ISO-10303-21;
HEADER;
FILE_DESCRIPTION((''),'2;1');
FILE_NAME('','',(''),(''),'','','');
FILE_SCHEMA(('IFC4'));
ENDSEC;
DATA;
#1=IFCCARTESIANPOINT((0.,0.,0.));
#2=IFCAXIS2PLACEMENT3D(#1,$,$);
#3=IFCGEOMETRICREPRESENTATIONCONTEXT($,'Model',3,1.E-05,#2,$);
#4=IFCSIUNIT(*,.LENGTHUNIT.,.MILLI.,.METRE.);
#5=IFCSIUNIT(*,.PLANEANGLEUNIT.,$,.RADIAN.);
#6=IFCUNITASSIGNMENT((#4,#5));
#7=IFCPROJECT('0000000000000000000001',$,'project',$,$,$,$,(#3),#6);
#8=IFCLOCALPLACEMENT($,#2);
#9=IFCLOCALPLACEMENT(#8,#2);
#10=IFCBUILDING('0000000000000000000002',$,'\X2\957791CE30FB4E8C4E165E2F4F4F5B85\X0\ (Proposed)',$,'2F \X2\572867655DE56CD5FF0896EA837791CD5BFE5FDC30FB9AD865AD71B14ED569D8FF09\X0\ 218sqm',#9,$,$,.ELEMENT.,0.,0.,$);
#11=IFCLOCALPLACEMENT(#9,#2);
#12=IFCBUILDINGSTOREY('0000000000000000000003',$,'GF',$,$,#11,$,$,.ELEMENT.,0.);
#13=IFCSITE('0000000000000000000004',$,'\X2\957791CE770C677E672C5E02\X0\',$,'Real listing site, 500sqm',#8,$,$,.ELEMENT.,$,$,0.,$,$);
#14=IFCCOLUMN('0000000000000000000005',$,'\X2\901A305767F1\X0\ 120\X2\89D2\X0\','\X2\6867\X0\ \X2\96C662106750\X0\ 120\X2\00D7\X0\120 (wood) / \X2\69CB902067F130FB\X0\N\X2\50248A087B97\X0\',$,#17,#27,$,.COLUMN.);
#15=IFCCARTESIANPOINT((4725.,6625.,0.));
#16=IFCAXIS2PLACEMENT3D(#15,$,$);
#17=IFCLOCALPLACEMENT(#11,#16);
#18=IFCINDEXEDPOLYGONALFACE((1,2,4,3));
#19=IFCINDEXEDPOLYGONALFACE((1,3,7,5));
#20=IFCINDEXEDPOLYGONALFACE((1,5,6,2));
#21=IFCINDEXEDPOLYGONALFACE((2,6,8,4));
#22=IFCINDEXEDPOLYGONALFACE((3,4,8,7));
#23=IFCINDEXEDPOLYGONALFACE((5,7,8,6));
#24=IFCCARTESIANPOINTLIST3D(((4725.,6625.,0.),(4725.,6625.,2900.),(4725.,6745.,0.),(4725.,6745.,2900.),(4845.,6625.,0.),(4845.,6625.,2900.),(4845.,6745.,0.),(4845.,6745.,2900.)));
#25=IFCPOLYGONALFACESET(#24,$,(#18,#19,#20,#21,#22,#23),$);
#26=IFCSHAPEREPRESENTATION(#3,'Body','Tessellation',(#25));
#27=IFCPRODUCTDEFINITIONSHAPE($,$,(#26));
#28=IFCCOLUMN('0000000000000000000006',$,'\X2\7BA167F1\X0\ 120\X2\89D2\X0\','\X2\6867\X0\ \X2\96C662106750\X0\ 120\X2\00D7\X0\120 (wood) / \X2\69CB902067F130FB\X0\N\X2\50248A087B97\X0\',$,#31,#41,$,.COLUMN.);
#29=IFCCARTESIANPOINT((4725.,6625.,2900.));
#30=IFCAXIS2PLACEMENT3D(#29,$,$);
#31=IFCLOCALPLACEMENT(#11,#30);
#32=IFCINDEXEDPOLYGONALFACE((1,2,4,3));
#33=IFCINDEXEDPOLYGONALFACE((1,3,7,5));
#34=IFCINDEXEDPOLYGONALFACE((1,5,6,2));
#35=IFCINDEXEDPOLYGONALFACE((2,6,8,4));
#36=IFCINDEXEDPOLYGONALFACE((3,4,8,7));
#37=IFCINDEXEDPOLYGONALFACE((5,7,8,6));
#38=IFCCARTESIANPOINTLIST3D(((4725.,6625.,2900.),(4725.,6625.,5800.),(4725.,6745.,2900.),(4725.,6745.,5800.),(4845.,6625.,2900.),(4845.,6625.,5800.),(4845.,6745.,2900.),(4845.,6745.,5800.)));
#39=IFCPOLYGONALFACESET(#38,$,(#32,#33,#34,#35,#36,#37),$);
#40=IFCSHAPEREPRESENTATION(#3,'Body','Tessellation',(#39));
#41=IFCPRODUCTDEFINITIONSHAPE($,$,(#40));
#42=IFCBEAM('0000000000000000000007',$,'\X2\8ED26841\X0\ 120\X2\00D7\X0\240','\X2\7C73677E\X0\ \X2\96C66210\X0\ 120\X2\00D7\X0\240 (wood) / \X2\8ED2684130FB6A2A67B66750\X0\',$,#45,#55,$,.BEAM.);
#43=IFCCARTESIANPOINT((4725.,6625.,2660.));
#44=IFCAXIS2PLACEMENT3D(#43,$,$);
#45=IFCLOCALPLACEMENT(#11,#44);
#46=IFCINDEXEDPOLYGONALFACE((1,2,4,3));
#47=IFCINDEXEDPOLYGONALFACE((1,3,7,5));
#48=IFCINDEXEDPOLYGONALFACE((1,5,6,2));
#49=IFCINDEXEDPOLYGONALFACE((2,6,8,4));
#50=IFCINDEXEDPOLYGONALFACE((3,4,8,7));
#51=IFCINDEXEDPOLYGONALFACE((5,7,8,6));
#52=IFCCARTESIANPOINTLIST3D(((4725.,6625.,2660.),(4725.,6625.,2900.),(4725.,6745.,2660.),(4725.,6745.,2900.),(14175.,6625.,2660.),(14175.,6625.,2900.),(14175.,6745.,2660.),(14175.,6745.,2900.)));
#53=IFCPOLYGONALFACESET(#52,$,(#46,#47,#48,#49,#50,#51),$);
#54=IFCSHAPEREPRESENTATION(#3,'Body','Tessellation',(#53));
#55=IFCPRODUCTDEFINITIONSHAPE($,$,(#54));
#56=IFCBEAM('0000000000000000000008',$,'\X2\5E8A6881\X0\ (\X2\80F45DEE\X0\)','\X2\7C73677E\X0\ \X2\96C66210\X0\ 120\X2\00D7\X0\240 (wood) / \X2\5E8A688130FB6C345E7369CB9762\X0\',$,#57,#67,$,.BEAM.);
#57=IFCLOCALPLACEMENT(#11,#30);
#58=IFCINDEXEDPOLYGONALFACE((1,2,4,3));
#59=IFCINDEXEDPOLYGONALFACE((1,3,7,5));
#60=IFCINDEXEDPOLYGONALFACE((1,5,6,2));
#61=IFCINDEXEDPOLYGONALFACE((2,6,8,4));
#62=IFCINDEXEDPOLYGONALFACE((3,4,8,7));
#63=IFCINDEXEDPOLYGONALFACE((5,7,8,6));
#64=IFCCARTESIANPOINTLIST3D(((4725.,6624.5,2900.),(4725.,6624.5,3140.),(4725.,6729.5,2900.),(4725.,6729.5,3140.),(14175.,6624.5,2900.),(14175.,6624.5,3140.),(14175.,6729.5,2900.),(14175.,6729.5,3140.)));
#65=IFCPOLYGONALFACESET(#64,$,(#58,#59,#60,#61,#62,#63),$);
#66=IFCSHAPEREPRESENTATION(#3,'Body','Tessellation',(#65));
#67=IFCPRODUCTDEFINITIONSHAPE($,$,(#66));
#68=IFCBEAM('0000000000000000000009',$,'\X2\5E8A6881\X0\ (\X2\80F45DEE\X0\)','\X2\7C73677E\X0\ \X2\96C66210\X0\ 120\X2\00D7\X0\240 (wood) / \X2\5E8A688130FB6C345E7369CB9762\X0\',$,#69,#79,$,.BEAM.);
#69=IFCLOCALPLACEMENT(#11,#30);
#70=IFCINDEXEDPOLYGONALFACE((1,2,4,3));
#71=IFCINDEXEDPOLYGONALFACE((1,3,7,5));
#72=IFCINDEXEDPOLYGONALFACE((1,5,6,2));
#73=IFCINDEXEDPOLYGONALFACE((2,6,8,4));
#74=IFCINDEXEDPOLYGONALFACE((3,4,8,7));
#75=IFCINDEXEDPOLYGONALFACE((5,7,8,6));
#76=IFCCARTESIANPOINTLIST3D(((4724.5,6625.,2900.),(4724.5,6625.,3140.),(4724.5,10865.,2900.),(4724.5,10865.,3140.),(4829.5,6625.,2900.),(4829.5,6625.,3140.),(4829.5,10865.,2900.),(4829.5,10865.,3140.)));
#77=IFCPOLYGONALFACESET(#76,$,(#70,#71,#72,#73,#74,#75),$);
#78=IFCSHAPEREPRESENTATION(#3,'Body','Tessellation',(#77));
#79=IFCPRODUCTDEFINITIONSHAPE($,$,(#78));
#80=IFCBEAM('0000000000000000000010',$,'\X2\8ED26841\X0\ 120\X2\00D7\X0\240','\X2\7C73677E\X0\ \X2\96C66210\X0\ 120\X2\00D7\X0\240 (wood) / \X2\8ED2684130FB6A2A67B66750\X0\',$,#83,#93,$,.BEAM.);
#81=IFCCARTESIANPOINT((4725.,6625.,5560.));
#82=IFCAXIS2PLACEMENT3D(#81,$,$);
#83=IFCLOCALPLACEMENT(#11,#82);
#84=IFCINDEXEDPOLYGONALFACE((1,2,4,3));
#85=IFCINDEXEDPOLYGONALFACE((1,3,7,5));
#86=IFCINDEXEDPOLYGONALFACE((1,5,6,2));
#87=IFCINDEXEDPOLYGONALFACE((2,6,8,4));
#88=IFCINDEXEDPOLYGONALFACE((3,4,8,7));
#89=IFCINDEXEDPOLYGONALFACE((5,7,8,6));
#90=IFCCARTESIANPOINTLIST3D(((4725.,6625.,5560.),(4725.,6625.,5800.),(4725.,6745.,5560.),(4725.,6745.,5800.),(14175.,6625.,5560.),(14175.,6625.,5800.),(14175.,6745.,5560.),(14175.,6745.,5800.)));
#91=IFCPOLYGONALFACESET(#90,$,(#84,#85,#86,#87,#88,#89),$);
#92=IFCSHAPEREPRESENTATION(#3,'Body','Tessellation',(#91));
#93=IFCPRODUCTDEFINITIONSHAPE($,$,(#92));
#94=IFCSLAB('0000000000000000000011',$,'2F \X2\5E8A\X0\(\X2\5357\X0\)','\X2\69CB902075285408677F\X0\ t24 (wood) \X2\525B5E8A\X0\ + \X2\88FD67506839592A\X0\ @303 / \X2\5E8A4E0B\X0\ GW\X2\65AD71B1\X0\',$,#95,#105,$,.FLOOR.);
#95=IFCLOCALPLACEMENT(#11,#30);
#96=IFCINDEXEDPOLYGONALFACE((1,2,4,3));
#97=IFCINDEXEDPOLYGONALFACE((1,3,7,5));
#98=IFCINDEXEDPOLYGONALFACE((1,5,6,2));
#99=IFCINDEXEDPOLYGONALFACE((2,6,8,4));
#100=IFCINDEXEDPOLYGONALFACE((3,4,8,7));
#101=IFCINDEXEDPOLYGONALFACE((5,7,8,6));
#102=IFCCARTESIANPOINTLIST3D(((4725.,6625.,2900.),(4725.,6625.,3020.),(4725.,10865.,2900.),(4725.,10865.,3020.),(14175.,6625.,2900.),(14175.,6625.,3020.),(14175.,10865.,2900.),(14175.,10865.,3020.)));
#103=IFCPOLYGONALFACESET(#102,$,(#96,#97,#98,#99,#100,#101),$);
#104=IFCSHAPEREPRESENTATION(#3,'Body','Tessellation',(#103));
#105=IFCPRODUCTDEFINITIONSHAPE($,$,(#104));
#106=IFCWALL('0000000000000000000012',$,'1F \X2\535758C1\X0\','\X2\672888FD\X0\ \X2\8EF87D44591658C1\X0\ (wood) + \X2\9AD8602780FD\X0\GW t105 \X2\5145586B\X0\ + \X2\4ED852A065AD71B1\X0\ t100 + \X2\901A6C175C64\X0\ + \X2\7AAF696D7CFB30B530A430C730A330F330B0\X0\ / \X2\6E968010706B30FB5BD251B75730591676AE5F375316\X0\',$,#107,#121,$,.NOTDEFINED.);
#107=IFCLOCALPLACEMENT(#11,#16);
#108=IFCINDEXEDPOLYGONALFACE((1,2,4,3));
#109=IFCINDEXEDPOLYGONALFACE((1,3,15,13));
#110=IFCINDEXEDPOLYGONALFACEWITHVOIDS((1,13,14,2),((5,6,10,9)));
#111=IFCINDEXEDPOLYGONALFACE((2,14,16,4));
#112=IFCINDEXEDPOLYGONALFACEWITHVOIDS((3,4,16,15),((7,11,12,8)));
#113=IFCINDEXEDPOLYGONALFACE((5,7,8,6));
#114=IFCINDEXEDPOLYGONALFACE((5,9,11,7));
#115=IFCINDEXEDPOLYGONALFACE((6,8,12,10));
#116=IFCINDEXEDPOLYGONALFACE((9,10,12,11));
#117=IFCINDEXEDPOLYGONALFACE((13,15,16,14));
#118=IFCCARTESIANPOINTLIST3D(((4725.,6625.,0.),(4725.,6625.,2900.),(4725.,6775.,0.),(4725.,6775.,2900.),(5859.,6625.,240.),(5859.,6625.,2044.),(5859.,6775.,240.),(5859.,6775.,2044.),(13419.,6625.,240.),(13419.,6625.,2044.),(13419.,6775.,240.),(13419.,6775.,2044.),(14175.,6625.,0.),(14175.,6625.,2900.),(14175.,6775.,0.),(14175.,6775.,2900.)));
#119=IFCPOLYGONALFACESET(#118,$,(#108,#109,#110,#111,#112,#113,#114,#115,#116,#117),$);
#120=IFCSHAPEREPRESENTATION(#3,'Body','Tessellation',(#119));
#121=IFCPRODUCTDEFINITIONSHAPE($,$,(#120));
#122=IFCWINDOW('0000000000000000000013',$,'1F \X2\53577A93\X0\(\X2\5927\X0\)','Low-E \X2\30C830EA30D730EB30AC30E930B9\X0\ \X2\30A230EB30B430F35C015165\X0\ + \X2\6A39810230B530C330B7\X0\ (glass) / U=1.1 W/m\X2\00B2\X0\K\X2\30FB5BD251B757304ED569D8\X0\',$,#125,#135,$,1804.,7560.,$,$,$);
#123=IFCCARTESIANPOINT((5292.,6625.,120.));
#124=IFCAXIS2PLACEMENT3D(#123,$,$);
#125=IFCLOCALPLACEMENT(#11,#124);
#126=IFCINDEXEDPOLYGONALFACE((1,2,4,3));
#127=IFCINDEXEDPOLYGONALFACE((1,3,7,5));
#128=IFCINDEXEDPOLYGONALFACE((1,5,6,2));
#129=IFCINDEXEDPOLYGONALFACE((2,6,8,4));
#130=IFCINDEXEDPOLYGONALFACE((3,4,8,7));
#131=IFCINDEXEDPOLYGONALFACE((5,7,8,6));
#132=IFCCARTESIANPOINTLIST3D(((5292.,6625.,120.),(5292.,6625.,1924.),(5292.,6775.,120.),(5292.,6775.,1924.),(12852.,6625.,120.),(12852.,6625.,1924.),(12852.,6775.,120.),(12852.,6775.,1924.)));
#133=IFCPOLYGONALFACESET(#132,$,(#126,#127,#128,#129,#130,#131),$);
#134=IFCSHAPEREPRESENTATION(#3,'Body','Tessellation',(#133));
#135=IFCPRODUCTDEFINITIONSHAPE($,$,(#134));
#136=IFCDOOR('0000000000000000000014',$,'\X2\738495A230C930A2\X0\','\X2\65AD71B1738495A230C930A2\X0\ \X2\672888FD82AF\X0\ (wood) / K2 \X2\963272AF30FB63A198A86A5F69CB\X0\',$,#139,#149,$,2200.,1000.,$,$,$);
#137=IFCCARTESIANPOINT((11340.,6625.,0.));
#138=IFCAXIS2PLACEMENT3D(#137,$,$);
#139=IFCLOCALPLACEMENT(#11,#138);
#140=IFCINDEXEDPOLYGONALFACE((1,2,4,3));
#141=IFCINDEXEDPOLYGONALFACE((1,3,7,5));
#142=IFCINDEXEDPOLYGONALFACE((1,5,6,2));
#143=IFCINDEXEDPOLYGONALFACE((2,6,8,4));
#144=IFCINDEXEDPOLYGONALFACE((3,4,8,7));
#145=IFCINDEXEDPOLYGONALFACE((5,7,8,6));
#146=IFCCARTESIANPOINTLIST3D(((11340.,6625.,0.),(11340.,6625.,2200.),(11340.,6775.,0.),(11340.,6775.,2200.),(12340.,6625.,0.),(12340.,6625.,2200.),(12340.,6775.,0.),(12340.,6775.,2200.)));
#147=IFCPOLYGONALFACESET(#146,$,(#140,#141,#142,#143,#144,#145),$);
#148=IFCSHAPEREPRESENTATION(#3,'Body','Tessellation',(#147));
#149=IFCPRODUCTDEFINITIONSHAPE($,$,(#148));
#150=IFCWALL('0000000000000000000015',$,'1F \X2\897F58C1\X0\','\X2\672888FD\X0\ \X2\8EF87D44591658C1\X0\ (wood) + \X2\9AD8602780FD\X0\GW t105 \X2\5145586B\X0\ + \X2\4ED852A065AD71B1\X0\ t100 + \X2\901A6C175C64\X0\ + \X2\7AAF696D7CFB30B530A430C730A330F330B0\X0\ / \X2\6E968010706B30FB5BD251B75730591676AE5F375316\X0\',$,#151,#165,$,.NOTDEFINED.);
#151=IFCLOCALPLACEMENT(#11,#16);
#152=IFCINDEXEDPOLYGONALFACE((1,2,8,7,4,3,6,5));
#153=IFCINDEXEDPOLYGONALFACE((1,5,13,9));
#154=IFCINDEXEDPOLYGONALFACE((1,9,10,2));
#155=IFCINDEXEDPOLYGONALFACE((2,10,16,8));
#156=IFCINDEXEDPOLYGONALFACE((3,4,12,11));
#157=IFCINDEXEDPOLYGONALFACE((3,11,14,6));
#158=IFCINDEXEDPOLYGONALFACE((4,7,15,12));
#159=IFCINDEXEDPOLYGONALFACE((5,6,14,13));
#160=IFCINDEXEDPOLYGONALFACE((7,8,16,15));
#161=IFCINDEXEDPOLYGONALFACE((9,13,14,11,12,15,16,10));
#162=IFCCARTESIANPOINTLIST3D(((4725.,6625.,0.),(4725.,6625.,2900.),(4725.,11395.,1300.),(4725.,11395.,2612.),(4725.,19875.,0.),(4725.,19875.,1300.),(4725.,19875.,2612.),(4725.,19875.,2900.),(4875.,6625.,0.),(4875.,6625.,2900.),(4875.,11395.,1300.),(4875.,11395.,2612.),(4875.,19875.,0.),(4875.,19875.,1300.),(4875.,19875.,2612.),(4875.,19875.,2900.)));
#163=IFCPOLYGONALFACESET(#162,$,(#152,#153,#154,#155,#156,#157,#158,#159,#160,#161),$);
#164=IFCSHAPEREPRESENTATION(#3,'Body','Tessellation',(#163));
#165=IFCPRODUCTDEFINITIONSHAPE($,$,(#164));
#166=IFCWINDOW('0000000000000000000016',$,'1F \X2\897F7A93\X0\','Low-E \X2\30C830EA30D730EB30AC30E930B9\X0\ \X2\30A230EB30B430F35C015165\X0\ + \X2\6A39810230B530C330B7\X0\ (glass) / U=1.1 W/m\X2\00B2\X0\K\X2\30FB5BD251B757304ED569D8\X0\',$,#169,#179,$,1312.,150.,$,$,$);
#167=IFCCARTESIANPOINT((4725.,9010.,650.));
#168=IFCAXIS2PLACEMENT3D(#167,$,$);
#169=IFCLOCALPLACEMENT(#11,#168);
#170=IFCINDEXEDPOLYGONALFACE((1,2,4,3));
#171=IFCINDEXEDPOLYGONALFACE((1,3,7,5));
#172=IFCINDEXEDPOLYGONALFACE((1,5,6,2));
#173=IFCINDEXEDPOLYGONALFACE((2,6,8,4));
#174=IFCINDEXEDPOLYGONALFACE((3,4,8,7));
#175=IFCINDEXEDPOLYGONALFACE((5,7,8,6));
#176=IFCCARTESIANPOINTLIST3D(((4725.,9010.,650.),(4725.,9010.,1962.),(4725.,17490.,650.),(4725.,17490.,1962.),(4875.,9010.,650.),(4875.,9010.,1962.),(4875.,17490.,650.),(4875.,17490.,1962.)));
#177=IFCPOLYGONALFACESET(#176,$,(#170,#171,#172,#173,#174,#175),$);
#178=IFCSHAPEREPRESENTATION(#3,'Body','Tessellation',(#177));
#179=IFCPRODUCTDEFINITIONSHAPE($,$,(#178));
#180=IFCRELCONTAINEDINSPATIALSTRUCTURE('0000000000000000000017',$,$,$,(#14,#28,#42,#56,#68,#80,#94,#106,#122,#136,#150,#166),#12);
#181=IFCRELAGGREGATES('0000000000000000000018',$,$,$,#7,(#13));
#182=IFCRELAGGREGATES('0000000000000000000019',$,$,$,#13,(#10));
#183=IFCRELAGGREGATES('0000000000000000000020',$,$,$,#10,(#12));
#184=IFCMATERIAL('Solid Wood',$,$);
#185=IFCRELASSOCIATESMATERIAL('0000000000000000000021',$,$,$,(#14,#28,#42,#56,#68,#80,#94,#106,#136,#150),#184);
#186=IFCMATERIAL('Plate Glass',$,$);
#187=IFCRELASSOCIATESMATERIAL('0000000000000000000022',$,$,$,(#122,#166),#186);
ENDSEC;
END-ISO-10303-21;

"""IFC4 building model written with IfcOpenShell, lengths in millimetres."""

from ifc_helpers import new_model, si_unit, frame, frame_2d, origin, place, context, project, spatial, rectangle, extrude, material, element, fill, save


model = new_model("IFC4")

# Units and contexts
model_context = context("Model", 3, precision=1e-05, world=origin())
ifc_project = project(units=[si_unit("LENGTHUNIT", "METRE", prefix="MILLI"), si_unit("PLANEANGLEUNIT", "RADIAN")], contexts=[model_context])

# Site, building, storey
site_placement = place(None, origin())
site = spatial("IfcSite", under=ifc_project, at=site_placement, Name="長野県松本市", ObjectType="Real listing site, 500sqm", CompositionType="ELEMENT", RefElevation=0.0)
building_placement = place(site_placement, origin())
building = spatial("IfcBuilding", under=site, at=building_placement, Name="長野・二世帯住宅 (Proposed)", ObjectType="2F 在来工法（雪荷重対応・高断熱仕様） 218sqm", CompositionType="ELEMENT", ElevationOfRefHeight=0.0, ElevationOfTerrain=0.0)
storey_placement = place(building_placement, origin())
storey = spatial("IfcBuildingStorey", under=building, at=storey_placement, Name="GF", CompositionType="ELEMENT", Elevation=0.0)

# Columns
ifc_material_1 = material(Name="Solid Wood")
column_1_placement = place(storey_placement, frame((4725.0, 6625.0, 0.0)))
element("IfcColumn", 1, at=column_1_placement, inside=storey, material=ifc_material_1, Name="通し柱 120角", Description="桧 集成材 120×120 (wood) / 構造柱・N値計算", PredefinedType="COLUMN", context=model_context, shape_type="SweptSolid", body=[
    extrude(rectangle(XDim=120.0, YDim=120.0, at=frame_2d((60.0, 60.0))), frame((4725.0, 6625.0, 0.0)), (0.0, 0.0, 1.0), 2900.0),
])
column_2_placement = place(storey_placement, frame((4725.0, 6625.0, 2900.0)))
element("IfcColumn", 2, at=column_2_placement, inside=storey, material=ifc_material_1, Name="管柱 120角", Description="桧 集成材 120×120 (wood) / 構造柱・N値計算", PredefinedType="COLUMN", context=model_context, shape_type="SweptSolid", body=[
    extrude(rectangle(XDim=120.0, YDim=120.0, at=frame_2d((60.0, 60.0))), frame((4725.0, 6625.0, 2900.0)), (0.0, 0.0, 1.0), 2900.0),
])

# Beams
beam_1_placement = place(storey_placement, frame((4725.0, 6625.0, 2660.0)))
element("IfcBeam", 3, at=beam_1_placement, inside=storey, material=ifc_material_1, Name="軒桁 120×240", Description="米松 集成 120×240 (wood) / 軒桁・横架材", PredefinedType="BEAM", context=model_context, shape_type="SweptSolid", body=[
    extrude(rectangle(XDim=9450.0, YDim=120.0, at=frame_2d((4725.0, 60.0))), frame((4725.0, 6625.0, 2660.0)), (0.0, 0.0, 1.0), 240.0),
])
beam_2_placement = place(storey_placement, frame((4725.0, 6625.0, 2900.0)))
element("IfcBeam", 4, at=beam_2_placement, inside=storey, material=ifc_material_1, Name="床梁 (胴差)", Description="米松 集成 120×240 (wood) / 床梁・水平構面", PredefinedType="BEAM", context=model_context, shape_type="SweptSolid", body=[
    extrude(rectangle(XDim=9450.0, YDim=105.0, at=frame_2d((4725.0, 52.0))), frame((4725.0, 6625.0, 2900.0)), (0.0, 0.0, 1.0), 240.0),
])
beam_3_placement = place(storey_placement, frame((4725.0, 6625.0, 2900.0)))
element("IfcBeam", 5, at=beam_3_placement, inside=storey, material=ifc_material_1, Name="床梁 (胴差)", Description="米松 集成 120×240 (wood) / 床梁・水平構面", PredefinedType="BEAM", context=model_context, shape_type="SweptSolid", body=[
    extrude(rectangle(XDim=105.0, YDim=4240.0, at=frame_2d((52.0, 2120.0))), frame((4725.0, 6625.0, 2900.0)), (0.0, 0.0, 1.0), 240.0),
])
beam_4_placement = place(storey_placement, frame((4725.0, 6625.0, 5560.0)))
element("IfcBeam", 6, at=beam_4_placement, inside=storey, material=ifc_material_1, Name="軒桁 120×240", Description="米松 集成 120×240 (wood) / 軒桁・横架材", PredefinedType="BEAM", context=model_context, shape_type="SweptSolid", body=[
    extrude(rectangle(XDim=9450.0, YDim=120.0, at=frame_2d((4725.0, 60.0))), frame((4725.0, 6625.0, 5560.0)), (0.0, 0.0, 1.0), 240.0),
])

# Slab
slab_1_placement = place(storey_placement, frame((4725.0, 6625.0, 2900.0)))
element("IfcSlab", 7, at=slab_1_placement, inside=storey, material=ifc_material_1, Name="2F 床(南)", Description="構造用合板 t24 (wood) 剛床 + 製材根太 @303 / 床下 GW断熱", PredefinedType="FLOOR", context=model_context, shape_type="SweptSolid", body=[
    extrude(rectangle(XDim=9450.0, YDim=4240.0, at=frame_2d((4725.0, 2120.0))), frame((4725.0, 6625.0, 2900.0)), (0.0, 0.0, 1.0), 120.0),
])

# Wall, openings, window, door
wall_1_placement = place(storey_placement, frame((4725.0, 6625.0, 0.0)))
wall_1 = element("IfcWall", 8, at=wall_1_placement, inside=storey, material=ifc_material_1, Name="1F 南壁", Description="木製 軸組外壁 (wood) + 高性能GW t105 充填 + 付加断熱 t100 + 通気層 + 窯業系サイディング / 準耐火・寒冷地外皮強化", PredefinedType="NOTDEFINED", context=model_context, shape_type="SweptSolid", body=[
    extrude(rectangle(XDim=9450.0, YDim=150.0, at=frame_2d((4725.0, 75.0))), frame((4725.0, 6625.0, 0.0)), (0.0, 0.0, 1.0), 2900.0),
])
opening_1_placement = place(storey_placement, frame((5292.0, 6625.0, 120.0)))
opening_1 = element("IfcOpeningElement", 9, at=opening_1_placement, cuts=wall_1, PredefinedType="NOTDEFINED", context=model_context, shape_type="SweptSolid", body=[
    extrude(rectangle(XDim=7560.0, YDim=150.0, at=frame_2d((3780.0, 75.0))), frame((5292.0, 6625.0, 120.0)), (0.0, 0.0, 1.0), 1804.0),
])
opening_2_placement = place(storey_placement, frame((11340.0, 6625.0, 0.0)))
opening_2 = element("IfcOpeningElement", 10, at=opening_2_placement, cuts=wall_1, PredefinedType="NOTDEFINED", context=model_context, shape_type="SweptSolid", body=[
    extrude(rectangle(XDim=1000.0, YDim=150.0, at=frame_2d((500.0, 75.0))), frame((11340.0, 6625.0, 0.0)), (0.0, 0.0, 1.0), 2200.0),
])
ifc_material_2 = material(Name="Plate Glass")
window_1_placement = place(storey_placement, frame((5292.0, 6625.0, 120.0)))
window_1 = element("IfcWindow", 11, at=window_1_placement, inside=storey, material=ifc_material_2, Name="1F 南窓(大)", Description="Low-E トリプルガラス アルゴン封入 + 樹脂サッシ (glass) / U=1.1 W/m²K・寒冷地仕様", OverallHeight=1804.0, OverallWidth=7560.0, context=model_context, shape_type="SweptSolid", body=[
    extrude(rectangle(XDim=7560.0, YDim=150.0, at=frame_2d((3780.0, 75.0))), frame((5292.0, 6625.0, 120.0)), (0.0, 0.0, 1.0), 1804.0),
])
fill(opening_1, window_1)
door_placement = place(storey_placement, frame((11340.0, 6625.0, 0.0)))
door = element("IfcDoor", 12, at=door_placement, inside=storey, material=ifc_material_1, Name="玄関ドア", Description="断熱玄関ドア 木製芯 (wood) / K2 防犯・採風機構", OverallHeight=2200.0, OverallWidth=1000.0, context=model_context, shape_type="SweptSolid", body=[
    extrude(rectangle(XDim=1000.0, YDim=150.0, at=frame_2d((500.0, 75.0))), frame((11340.0, 6625.0, 0.0)), (0.0, 0.0, 1.0), 2200.0),
])
fill(opening_2, door)

# Wall, opening, window
wall_2_placement = place(storey_placement, frame((4725.0, 6625.0, 0.0)))
wall_2 = element("IfcWall", 13, at=wall_2_placement, inside=storey, material=ifc_material_1, Name="1F 西壁", Description="木製 軸組外壁 (wood) + 高性能GW t105 充填 + 付加断熱 t100 + 通気層 + 窯業系サイディング / 準耐火・寒冷地外皮強化", PredefinedType="NOTDEFINED", context=model_context, shape_type="SweptSolid", body=[
    extrude(rectangle(XDim=150.0, YDim=13250.0, at=frame_2d((75.0, 6625.0))), frame((4725.0, 6625.0, 0.0)), (0.0, 0.0, 1.0), 2900.0),
])
opening_3_placement = place(storey_placement, frame((4725.0, 9010.0, 650.0)))
opening_3 = element("IfcOpeningElement", 14, at=opening_3_placement, cuts=wall_2, PredefinedType="NOTDEFINED", context=model_context, shape_type="SweptSolid", body=[
    extrude(rectangle(XDim=150.0, YDim=8480.0, at=frame_2d((75.0, 4240.0))), frame((4725.0, 9010.0, 650.0)), (0.0, 0.0, 1.0), 1312.0),
])
window_2_placement = place(storey_placement, frame((4725.0, 9010.0, 650.0)))
window_2 = element("IfcWindow", 15, at=window_2_placement, inside=storey, material=ifc_material_2, Name="1F 西窓", Description="Low-E トリプルガラス アルゴン封入 + 樹脂サッシ (glass) / U=1.1 W/m²K・寒冷地仕様", OverallHeight=1312.0, OverallWidth=150.0, context=model_context, shape_type="SweptSolid", body=[
    extrude(rectangle(XDim=150.0, YDim=8480.0, at=frame_2d((75.0, 4240.0))), frame((4725.0, 9010.0, 650.0)), (0.0, 0.0, 1.0), 1312.0),
])
fill(opening_3, window_2)

save(model, "model.ifc")
